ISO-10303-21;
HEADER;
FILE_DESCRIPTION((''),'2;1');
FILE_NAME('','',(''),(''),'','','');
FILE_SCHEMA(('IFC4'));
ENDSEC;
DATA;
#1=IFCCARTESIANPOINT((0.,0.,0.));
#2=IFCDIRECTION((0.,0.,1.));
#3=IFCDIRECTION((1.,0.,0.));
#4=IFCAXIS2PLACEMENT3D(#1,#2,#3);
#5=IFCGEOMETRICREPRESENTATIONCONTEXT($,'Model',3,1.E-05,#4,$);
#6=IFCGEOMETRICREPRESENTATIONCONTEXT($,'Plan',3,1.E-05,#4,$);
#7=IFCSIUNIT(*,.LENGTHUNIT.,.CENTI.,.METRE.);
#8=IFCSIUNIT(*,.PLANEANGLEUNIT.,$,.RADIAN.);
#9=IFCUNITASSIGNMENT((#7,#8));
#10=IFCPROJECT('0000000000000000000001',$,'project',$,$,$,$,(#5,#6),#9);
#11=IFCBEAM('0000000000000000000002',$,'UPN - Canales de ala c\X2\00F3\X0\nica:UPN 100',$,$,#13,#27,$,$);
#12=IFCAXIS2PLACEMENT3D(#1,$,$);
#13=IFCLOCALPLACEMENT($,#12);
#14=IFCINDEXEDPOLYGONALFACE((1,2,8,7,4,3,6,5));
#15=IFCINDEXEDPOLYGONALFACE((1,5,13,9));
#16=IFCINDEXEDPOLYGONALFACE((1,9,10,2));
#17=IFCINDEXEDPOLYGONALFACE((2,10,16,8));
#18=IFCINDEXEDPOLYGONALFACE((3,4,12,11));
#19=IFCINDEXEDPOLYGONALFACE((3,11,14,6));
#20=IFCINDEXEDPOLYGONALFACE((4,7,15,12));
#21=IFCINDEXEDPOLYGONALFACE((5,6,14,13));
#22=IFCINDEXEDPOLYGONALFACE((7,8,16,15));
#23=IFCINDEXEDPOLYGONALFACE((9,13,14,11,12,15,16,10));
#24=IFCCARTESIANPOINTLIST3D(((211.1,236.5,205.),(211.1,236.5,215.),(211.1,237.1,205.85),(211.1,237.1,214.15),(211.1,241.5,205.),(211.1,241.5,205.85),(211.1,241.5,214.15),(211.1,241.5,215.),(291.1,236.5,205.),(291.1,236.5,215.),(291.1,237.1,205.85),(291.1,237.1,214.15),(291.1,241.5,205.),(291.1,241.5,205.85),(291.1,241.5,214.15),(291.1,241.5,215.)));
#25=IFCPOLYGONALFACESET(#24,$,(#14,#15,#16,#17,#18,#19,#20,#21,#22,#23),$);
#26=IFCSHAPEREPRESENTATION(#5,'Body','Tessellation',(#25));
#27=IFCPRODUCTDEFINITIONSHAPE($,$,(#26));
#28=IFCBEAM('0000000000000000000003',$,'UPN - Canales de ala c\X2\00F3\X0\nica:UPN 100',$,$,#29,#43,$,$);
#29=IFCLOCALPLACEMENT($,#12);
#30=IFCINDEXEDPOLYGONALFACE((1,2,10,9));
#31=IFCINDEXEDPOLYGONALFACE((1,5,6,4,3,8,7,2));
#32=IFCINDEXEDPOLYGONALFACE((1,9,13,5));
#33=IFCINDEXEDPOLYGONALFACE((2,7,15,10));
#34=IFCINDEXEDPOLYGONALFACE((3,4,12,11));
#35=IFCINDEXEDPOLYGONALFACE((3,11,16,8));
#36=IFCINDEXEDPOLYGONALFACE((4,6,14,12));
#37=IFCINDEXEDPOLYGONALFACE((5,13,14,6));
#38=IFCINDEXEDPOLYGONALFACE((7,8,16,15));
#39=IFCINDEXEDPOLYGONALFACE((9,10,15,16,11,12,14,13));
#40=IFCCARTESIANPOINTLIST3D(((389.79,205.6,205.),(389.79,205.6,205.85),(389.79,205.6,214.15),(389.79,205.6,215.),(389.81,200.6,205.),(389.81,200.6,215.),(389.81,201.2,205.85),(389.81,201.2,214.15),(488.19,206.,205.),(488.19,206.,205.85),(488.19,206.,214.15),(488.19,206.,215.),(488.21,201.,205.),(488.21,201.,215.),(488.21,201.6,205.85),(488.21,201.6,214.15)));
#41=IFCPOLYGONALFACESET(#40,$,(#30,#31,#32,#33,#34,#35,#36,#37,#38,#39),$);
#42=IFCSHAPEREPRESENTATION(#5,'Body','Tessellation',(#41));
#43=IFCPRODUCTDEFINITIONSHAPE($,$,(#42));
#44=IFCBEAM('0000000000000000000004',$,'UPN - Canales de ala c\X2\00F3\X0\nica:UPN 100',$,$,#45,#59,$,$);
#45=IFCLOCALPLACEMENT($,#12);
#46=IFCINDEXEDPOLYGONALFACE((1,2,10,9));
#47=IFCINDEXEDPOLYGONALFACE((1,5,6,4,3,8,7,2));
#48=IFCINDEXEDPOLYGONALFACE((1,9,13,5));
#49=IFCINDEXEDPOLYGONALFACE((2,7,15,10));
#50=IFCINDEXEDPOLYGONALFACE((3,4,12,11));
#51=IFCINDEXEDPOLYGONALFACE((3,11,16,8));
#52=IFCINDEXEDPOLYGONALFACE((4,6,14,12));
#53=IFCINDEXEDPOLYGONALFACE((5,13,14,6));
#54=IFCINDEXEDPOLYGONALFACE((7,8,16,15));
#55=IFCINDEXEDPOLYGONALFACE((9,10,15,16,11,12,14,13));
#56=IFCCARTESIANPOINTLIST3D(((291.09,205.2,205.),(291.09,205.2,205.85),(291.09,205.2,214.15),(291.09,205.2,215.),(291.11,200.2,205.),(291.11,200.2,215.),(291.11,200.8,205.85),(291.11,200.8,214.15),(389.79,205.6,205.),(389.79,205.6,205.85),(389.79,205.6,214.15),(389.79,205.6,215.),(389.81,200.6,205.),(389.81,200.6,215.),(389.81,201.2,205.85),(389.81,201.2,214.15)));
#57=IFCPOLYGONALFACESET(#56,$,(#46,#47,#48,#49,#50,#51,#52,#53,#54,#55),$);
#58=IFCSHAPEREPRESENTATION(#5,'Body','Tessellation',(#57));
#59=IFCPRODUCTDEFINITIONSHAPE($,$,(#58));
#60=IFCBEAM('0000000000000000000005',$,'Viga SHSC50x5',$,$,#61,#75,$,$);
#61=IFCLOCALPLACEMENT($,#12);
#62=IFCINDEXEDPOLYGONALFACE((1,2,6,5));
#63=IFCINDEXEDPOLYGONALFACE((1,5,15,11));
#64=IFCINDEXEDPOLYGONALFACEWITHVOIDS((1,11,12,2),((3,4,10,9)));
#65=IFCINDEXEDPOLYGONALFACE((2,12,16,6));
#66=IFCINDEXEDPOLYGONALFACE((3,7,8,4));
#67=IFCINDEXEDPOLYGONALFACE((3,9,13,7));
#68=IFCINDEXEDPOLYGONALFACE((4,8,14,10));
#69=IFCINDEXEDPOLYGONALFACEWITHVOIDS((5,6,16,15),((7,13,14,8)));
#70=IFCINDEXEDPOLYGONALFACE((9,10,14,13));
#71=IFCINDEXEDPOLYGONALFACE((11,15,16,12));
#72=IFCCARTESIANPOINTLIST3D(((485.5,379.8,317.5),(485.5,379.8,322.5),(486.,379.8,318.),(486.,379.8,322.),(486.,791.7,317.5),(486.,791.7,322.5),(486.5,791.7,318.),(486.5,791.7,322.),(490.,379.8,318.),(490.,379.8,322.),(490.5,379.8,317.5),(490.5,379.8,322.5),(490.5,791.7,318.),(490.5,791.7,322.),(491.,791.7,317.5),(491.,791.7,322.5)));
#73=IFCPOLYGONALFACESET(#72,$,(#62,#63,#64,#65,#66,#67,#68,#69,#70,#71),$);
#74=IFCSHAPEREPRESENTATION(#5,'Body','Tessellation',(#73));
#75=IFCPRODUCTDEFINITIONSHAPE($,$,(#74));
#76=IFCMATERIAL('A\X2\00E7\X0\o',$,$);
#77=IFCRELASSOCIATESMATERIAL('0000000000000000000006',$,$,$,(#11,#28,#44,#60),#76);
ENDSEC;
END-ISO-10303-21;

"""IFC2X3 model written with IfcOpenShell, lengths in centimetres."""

from ifc_helpers import new_model, si_unit, frame, frame_2d, origin_with_axes, origin_2d_with_axis, place, context, project, polyline, rectangle, u_section, outline, extrude, material, element, save


model = new_model("IFC2X3")

# Units and contexts
model_context = context("Model", 3, precision=1e-05, world=origin_with_axes())
plan_context = context("Plan", 3, precision=1e-05, world=origin_with_axes())
ifc_project = project(units=[si_unit("LENGTHUNIT", "METRE", prefix="CENTI"), si_unit("PLANEANGLEUNIT", "RADIAN")], contexts=[model_context, plan_context])

# Shared definitions
ifc_material = material(Name="Aço")

# Beams
beam_1_placement = place(None, frame((291.1, 239.0, 210.0), z_axis=(-1.0, 0.0, 0.0), x_axis=(0.0, 1.0, 0.0)))
element("IfcBeam", 1, at=beam_1_placement, material=ifc_material, Name="UPN - Canales de ala cónica:UPN 100", context=model_context, shape_type="SweptSolid", body=[
    extrude(u_section(Depth=10.0, FlangeWidth=5.0, WebThickness=0.6, FlangeThickness=0.85, FilletRadius=0.0, EdgeRadius=0.0, FlangeSlope=0.0, CentreOfGravityInX=0.0, at=origin_2d_with_axis()), origin_with_axes(), (0.0, 0.0, 1.0), 80.0),
])
beam_2_placement = place(None, frame((389.8, 203.1, 210.0), z_axis=(0.999992, 0.004065, 0.0), x_axis=(-0.004065, 0.999992, 0.0)))
element("IfcBeam", 2, at=beam_2_placement, material=ifc_material, Name="UPN - Canales de ala cónica:UPN 100", context=model_context, shape_type="SweptSolid", body=[
    extrude(u_section(Depth=10.0, FlangeWidth=5.0, WebThickness=0.6, FlangeThickness=0.85, FilletRadius=0.0, EdgeRadius=0.0, FlangeSlope=0.0, CentreOfGravityInX=0.0, at=frame_2d((0.0, 0.0), x_axis=(1.0, 0.0))), origin_with_axes(), (0.0, 0.0, 1.0), 98.4),
])
beam_3_placement = place(None, frame((291.1, 202.7, 210.0), z_axis=(0.999992, 0.004053, 0.0), x_axis=(-0.004053, 0.999992, 0.0)))
element("IfcBeam", 3, at=beam_3_placement, material=ifc_material, Name="UPN - Canales de ala cónica:UPN 100", context=model_context, shape_type="SweptSolid", body=[
    extrude(u_section(Depth=10.0, FlangeWidth=5.0, WebThickness=0.6, FlangeThickness=0.85, FilletRadius=0.0, EdgeRadius=0.0, FlangeSlope=0.0, CentreOfGravityInX=0.0, at=frame_2d((0.0, 0.0), x_axis=(1.0, 0.0))), origin_with_axes(), (0.0, 0.0, 1.0), 98.7),
])

# Beam, opening
placement = place(None, frame((488.0, 379.8, 320.0), z_axis=(0.001214, 0.999999, 0.0), x_axis=(0.999999, -0.001214, 0.0)))
beam_4 = element("IfcBeam", 4, at=placement, material=ifc_material, Name="Viga SHSC50x5", context=model_context, shape_type="SweptSolid", body=[
    extrude(rectangle(XDim=5.0, YDim=5.0, at=frame_2d((0.0, 0.0), x_axis=(1.0, 0.0))), origin_with_axes(), (0.0, 0.0, 1.0), 411.9),
])
element("IfcOpeningElement", 5, at=placement, cuts=beam_4, context=model_context, shape_type="SweptSolid", body=[
    extrude(outline(polyline([(2.0, -2.0), (-2.0, -2.0), (-2.0, 2.0), (2.0, 2.0), (2.0, -2.0)])), origin_with_axes(), (0.0, 0.0, 1.0), 411.9),
])

save(model, "model.ifc")
